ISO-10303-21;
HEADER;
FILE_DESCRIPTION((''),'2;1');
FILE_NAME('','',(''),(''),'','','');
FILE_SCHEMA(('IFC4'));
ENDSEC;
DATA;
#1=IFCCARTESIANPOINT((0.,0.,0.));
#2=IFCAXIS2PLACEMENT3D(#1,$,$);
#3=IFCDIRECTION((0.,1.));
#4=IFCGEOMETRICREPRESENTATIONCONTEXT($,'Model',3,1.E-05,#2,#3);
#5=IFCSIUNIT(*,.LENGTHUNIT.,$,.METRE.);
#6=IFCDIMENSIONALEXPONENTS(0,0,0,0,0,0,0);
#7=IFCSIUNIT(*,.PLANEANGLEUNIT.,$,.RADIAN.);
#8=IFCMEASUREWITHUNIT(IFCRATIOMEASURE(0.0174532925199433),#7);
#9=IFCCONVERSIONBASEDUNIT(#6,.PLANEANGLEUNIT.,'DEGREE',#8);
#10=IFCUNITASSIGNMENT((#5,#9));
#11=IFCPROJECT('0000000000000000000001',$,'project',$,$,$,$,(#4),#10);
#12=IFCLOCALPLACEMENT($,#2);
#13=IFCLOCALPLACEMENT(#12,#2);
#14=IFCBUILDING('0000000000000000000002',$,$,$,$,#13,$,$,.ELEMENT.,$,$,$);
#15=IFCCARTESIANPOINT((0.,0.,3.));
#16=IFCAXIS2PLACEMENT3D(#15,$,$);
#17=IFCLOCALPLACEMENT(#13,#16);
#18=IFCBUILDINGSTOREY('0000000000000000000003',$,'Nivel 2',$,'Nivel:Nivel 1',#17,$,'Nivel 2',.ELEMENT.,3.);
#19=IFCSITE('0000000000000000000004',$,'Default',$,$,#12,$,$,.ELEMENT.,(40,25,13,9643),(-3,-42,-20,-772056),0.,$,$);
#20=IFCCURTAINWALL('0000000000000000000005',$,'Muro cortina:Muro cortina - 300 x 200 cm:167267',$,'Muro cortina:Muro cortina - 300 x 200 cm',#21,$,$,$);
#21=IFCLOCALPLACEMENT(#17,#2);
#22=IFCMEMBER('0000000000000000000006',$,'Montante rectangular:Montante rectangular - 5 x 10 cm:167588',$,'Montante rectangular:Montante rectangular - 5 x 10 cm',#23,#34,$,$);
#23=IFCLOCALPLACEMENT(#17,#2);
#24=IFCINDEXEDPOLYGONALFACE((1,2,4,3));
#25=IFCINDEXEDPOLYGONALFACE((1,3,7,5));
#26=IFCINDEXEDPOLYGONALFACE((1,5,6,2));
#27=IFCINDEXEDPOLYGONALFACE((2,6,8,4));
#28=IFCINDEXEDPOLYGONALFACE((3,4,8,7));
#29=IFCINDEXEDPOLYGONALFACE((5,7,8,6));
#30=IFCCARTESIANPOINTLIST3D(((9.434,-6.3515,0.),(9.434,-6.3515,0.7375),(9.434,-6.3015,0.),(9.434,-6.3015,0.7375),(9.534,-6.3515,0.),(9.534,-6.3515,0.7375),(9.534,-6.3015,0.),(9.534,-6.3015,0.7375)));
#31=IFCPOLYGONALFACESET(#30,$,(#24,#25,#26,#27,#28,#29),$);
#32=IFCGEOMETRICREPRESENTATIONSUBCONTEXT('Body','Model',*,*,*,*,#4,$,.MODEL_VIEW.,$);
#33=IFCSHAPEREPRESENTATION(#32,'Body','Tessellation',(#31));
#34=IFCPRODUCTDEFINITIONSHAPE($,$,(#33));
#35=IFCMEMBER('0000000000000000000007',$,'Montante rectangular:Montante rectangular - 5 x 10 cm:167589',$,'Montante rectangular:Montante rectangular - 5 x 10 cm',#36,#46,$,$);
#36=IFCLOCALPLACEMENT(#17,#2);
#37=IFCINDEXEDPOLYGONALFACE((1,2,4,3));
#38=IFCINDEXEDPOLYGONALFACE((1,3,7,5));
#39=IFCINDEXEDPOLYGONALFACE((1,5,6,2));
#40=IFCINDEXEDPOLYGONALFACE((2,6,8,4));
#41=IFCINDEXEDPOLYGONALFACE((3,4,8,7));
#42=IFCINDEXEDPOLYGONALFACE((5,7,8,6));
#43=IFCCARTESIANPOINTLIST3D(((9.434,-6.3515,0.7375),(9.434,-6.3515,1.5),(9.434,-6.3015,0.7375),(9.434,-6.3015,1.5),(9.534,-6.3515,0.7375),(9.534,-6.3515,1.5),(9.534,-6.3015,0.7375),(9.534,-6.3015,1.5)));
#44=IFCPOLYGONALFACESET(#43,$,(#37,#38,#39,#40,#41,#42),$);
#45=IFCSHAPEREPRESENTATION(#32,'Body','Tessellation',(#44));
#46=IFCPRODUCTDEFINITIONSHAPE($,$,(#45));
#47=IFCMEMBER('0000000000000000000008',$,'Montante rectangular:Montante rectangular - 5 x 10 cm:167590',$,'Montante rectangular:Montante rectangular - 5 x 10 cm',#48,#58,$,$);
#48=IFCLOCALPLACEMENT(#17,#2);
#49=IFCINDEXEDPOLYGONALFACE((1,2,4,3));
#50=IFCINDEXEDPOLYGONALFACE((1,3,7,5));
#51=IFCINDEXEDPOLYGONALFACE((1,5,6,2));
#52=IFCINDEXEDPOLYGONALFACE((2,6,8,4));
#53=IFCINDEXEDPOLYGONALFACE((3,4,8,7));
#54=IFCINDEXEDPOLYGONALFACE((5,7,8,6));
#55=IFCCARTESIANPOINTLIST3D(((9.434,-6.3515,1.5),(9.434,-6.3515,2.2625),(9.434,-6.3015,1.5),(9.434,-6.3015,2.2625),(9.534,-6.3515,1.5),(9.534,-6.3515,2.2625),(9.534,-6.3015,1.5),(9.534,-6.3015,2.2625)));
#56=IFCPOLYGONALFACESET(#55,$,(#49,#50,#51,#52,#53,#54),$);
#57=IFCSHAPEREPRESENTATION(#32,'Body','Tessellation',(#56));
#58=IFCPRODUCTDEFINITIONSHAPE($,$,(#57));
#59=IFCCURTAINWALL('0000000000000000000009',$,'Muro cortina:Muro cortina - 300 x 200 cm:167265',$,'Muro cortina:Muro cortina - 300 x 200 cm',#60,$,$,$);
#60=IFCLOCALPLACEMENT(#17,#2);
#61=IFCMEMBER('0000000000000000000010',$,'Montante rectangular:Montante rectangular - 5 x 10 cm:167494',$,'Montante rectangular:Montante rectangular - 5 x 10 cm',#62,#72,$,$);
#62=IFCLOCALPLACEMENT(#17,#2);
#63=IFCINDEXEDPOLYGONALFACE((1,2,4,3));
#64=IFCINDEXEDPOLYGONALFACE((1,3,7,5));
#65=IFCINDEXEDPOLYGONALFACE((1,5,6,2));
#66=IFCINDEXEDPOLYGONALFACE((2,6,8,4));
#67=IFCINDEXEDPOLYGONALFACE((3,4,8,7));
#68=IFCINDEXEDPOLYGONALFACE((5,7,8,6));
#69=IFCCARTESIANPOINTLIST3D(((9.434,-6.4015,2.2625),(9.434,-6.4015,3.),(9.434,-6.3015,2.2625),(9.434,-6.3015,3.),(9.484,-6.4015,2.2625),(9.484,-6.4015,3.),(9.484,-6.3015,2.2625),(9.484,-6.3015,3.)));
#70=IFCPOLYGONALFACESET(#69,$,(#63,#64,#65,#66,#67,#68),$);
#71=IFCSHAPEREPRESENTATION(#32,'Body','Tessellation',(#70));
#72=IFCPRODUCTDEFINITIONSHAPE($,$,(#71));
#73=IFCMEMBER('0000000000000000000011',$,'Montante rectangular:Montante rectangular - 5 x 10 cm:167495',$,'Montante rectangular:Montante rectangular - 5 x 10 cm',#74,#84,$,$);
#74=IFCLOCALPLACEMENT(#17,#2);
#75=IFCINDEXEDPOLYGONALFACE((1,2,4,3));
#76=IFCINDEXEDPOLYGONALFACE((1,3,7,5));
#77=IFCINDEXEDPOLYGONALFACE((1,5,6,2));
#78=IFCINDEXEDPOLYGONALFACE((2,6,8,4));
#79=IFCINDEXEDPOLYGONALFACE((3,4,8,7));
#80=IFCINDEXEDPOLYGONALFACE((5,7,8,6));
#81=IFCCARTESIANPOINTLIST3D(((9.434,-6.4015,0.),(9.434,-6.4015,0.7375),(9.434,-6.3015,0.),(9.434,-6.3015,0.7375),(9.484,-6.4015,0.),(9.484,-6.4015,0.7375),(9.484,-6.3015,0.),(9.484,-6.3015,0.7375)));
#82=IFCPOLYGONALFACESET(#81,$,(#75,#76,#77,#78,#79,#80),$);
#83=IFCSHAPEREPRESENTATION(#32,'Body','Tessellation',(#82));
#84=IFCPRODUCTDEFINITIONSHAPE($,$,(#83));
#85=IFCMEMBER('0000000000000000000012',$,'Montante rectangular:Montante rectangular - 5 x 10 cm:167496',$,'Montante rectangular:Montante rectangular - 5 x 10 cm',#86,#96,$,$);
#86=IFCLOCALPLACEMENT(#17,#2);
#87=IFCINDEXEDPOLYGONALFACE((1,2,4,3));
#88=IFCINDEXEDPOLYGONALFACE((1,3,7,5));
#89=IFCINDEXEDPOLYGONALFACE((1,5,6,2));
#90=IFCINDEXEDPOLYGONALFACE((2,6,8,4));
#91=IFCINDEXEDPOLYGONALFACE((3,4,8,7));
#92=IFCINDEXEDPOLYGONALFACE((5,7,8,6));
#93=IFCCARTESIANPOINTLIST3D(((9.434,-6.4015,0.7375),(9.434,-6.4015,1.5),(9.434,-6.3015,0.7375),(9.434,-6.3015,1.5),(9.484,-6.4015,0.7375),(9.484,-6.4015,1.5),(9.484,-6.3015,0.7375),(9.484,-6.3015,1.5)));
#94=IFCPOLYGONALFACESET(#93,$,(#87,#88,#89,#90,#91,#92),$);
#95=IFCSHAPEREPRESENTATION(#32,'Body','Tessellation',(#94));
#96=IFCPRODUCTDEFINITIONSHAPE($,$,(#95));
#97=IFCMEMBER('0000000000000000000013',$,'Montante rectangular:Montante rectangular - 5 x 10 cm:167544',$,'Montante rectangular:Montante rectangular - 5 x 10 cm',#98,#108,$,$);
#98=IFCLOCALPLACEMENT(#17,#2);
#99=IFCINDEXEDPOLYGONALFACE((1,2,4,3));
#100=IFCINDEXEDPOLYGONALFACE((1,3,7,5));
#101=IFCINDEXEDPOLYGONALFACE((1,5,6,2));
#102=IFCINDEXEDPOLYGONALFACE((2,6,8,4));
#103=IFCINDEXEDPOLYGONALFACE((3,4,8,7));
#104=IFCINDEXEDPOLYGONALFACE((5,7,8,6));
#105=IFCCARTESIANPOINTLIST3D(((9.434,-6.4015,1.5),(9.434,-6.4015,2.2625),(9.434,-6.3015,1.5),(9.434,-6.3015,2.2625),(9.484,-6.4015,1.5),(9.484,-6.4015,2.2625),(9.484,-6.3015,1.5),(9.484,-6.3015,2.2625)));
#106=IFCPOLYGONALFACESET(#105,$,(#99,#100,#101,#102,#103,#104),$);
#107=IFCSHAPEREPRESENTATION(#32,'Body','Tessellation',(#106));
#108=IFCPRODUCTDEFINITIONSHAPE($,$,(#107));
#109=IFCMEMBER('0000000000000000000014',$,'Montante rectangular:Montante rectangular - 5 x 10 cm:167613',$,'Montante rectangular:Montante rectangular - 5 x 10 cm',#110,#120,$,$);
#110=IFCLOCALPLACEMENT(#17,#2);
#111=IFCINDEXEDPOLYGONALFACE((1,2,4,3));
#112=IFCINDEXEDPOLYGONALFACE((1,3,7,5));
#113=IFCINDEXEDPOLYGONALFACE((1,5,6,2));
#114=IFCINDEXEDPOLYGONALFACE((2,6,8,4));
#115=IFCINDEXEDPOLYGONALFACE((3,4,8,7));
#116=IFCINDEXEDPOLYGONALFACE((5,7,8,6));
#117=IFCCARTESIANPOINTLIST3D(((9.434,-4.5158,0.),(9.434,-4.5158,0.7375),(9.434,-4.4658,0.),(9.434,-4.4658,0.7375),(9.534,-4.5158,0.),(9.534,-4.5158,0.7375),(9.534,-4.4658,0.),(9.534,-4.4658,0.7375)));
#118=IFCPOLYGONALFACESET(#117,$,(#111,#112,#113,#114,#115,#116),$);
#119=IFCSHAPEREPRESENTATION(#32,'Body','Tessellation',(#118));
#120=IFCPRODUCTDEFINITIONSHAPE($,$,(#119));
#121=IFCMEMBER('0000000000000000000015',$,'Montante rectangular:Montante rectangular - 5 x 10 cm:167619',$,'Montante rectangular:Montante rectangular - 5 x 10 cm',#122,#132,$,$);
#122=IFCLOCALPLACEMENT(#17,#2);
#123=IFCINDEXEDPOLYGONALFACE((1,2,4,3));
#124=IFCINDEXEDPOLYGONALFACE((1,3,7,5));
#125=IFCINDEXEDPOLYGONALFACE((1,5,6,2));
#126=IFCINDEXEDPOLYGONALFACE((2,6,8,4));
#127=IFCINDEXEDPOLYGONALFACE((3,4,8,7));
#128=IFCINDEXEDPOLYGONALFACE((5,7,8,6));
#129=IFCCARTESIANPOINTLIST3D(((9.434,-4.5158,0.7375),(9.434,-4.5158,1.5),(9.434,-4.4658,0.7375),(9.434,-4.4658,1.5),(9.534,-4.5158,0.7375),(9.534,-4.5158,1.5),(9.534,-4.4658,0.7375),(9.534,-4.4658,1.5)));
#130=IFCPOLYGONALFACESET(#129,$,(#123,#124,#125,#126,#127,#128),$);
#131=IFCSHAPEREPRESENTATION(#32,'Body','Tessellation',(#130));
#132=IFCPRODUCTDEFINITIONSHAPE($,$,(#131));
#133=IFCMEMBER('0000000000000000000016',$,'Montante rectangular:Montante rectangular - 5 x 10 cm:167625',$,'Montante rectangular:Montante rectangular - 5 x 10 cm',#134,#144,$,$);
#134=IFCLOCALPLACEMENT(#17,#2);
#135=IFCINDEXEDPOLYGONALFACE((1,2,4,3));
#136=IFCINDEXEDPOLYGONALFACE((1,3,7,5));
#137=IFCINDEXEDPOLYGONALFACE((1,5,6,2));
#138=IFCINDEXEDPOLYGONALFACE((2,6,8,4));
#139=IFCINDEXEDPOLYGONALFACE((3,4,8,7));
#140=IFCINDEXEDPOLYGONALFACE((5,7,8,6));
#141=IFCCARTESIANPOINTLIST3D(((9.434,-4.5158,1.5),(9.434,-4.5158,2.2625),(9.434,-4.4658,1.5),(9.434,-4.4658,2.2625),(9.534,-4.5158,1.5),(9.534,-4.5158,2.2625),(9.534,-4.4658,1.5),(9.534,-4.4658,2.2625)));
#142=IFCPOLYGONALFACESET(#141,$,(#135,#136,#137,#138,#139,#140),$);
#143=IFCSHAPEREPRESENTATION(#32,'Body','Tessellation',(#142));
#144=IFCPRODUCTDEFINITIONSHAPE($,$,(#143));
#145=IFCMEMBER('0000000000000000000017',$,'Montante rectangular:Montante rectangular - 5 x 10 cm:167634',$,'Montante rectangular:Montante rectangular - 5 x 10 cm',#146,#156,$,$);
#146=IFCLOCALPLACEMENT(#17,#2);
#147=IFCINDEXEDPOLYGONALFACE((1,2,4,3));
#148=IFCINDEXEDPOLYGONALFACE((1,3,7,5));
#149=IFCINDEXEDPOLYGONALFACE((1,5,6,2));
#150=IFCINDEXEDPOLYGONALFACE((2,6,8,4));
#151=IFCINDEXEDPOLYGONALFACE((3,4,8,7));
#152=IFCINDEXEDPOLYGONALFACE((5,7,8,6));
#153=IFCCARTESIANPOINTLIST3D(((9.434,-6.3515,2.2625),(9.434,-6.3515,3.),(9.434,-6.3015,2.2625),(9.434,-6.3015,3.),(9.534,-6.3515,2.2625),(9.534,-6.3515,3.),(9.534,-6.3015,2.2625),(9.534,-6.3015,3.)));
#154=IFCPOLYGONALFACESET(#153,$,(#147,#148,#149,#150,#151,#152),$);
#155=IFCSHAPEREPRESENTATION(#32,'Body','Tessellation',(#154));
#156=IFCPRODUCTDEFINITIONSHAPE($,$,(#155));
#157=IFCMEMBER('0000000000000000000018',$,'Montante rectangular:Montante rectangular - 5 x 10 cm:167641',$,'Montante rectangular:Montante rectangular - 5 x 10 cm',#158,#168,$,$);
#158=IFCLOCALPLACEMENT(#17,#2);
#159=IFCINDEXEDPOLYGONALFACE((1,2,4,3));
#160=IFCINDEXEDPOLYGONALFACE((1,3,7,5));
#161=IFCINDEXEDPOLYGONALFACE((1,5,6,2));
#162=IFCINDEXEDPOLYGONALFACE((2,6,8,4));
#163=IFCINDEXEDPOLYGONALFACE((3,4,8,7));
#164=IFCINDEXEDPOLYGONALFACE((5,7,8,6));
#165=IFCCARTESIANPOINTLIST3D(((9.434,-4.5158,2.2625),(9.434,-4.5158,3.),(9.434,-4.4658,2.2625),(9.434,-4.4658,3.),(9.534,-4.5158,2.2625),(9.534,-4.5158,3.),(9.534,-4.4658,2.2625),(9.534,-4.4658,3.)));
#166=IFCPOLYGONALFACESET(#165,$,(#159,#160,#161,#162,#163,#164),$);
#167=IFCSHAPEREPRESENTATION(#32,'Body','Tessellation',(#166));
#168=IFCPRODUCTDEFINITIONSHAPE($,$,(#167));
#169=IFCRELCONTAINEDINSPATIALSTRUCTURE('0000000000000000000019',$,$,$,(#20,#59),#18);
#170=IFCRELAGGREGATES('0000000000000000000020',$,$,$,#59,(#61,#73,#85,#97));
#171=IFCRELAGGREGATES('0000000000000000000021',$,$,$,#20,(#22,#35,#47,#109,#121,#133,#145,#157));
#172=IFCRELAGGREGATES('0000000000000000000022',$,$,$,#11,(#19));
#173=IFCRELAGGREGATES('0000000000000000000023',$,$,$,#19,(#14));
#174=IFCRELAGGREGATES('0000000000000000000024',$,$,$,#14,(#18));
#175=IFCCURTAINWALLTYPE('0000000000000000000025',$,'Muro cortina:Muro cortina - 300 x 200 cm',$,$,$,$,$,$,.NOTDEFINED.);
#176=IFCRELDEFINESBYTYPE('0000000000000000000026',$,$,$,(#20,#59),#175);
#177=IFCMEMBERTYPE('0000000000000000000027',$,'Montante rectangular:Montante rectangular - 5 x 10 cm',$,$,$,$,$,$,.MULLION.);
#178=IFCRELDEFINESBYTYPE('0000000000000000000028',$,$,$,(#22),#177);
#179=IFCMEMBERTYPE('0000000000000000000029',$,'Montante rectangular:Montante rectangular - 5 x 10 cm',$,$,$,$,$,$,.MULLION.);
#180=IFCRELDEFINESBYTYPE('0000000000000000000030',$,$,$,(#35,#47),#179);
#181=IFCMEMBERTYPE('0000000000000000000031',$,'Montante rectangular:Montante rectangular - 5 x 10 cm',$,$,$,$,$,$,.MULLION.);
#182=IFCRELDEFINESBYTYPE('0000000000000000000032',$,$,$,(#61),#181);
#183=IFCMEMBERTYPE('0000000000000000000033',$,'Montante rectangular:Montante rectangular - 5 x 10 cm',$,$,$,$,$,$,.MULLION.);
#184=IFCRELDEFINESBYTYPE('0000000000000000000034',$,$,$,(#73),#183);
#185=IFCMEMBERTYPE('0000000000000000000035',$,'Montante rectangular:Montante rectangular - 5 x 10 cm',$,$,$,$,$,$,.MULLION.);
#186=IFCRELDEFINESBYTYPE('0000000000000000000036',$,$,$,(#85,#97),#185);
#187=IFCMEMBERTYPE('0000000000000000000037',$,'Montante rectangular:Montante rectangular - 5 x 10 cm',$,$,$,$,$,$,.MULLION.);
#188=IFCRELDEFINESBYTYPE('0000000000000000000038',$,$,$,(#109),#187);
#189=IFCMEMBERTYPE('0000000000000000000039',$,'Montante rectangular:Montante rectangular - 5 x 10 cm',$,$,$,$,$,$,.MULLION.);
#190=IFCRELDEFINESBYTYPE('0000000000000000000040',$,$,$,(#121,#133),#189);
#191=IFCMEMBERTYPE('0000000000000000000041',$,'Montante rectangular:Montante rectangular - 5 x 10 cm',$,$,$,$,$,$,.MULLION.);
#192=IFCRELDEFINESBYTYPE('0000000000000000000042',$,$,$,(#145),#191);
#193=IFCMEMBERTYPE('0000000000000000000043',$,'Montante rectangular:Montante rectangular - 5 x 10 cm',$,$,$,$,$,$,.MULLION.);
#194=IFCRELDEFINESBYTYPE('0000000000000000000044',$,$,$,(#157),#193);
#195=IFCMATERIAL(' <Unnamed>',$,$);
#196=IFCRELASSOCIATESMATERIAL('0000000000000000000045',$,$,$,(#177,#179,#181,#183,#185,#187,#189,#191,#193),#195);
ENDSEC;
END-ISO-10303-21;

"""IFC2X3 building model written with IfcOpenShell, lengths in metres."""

from ifc_helpers import new_model, entity, si_unit, converted_unit, direction, frame, origin, origin_2d_with_axis, place, context, subcontext, project, spatial, rectangle, extrude, source, transform, mapped, material, type_object, type_shapes, element, aggregate, save


model = new_model("IFC2X3")

# Units and contexts
model_context = context("Model", 3, precision=1e-05, world=origin(), true_north=direction((0.0, 1.0)))
body_context = subcontext(model_context, "Body", "Model", "MODEL_VIEW")
ifc_project = project(units=[si_unit("LENGTHUNIT", "METRE"), converted_unit("PLANEANGLEUNIT", "DEGREE", entity("IfcRatioMeasure", 0.0174532925199433), si_unit("PLANEANGLEUNIT", "RADIAN"), dimensions=[0, 0, 0, 0, 0, 0, 0])], contexts=[model_context])

# Site, building, storey
site_placement = place(None, origin())
site = spatial("IfcSite", under=ifc_project, at=site_placement, Name="Default", CompositionType="ELEMENT", RefLatitude=(40, 25, 13, 9643), RefLongitude=(-3, -42, -20, -772056), RefElevation=0.0)
building_placement = place(site_placement, origin())
building = spatial("IfcBuilding", under=site, at=building_placement, CompositionType="ELEMENT")
storey_placement = place(building_placement, frame((0.0, 0.0, 3.0)))
storey = spatial("IfcBuildingStorey", under=building, at=storey_placement, Name="Nivel 2", ObjectType="Nivel:Nivel 1", LongName="Nivel 2", CompositionType="ELEMENT", Elevation=3.0)

# Curtain walls, members
curtain_wall_type = type_object("IfcCurtainWallType", Name="Muro cortina:Muro cortina - 300 x 200 cm", PredefinedType="NOTDEFINED")
curtain_wall_1_placement = place(storey_placement, frame((0.0, 0.0, -3.0)))
curtain_wall_1 = element("IfcCurtainWall", 1, at=curtain_wall_1_placement, inside=storey, type_object=curtain_wall_type, Name="Muro cortina:Muro cortina - 300 x 200 cm:167267", ObjectType="Muro cortina:Muro cortina - 300 x 200 cm")
ifc_material_1 = material(Name=" <Unnamed>")
member_type_1 = type_object("IfcMemberType", Name="Montante rectangular:Montante rectangular - 5 x 10 cm", PredefinedType="MULLION", material=ifc_material_1)
shared_shape_1 = source(origin(), body_context, "Body", "SweptSolid", [
    extrude(rectangle(XDim=0.1, YDim=0.05, at=origin_2d_with_axis()), frame((-0.025, 0.0, -0.7375), z_axis=(0.0, 0.0, 1.0), x_axis=(0.0, -1.0, 0.0)), (0.0, 0.0, 1.0), 0.7375),
])
type_shapes(member_type_1, [shared_shape_1])
member_1_placement = place(storey_placement, frame((9.484, -6.3515, 0.0), z_axis=(0.0, 0.0, -1.0), x_axis=(0.0, -1.0, 0.0)))
member_1 = element("IfcMember", 2, at=member_1_placement, type_object=member_type_1, Name="Montante rectangular:Montante rectangular - 5 x 10 cm:167588", ObjectType="Montante rectangular:Montante rectangular - 5 x 10 cm", context=body_context, shape_type="MappedRepresentation", body=[
    mapped(shared_shape_1, transform((0.0, 0.0, 0.0), scale=1.0)),
])
member_type_2 = type_object("IfcMemberType", Name="Montante rectangular:Montante rectangular - 5 x 10 cm", PredefinedType="MULLION", material=ifc_material_1)
shared_shape_2 = source(origin(), body_context, "Body", "SweptSolid", [
    extrude(rectangle(XDim=0.1, YDim=0.05, at=origin_2d_with_axis()), frame((-0.025, 0.0, -0.7625), z_axis=(0.0, 0.0, 1.0), x_axis=(0.0, -1.0, 0.0)), (0.0, 0.0, 1.0), 0.7625),
])
type_shapes(member_type_2, [shared_shape_2])
member_2_placement = place(storey_placement, frame((9.484, -6.3515, 0.7375), z_axis=(0.0, 0.0, -1.0), x_axis=(0.0, -1.0, 0.0)))
member_2 = element("IfcMember", 3, at=member_2_placement, type_object=member_type_2, Name="Montante rectangular:Montante rectangular - 5 x 10 cm:167589", ObjectType="Montante rectangular:Montante rectangular - 5 x 10 cm", context=body_context, shape_type="MappedRepresentation", body=[
    mapped(shared_shape_2, transform((0.0, 0.0, 0.0), scale=1.0)),
])
member_3_placement = place(storey_placement, frame((9.484, -6.3515, 1.5), z_axis=(0.0, 0.0, -1.0), x_axis=(0.0, -1.0, 0.0)))
member_3 = element("IfcMember", 4, at=member_3_placement, type_object=member_type_2, Name="Montante rectangular:Montante rectangular - 5 x 10 cm:167590", ObjectType="Montante rectangular:Montante rectangular - 5 x 10 cm", context=body_context, shape_type="MappedRepresentation", body=[
    mapped(shared_shape_2, transform((0.0, 0.0, 0.0), scale=1.0)),
])
curtain_wall_2_placement = place(storey_placement, frame((0.0, 0.0, -3.0)))
curtain_wall_2 = element("IfcCurtainWall", 5, at=curtain_wall_2_placement, inside=storey, type_object=curtain_wall_type, Name="Muro cortina:Muro cortina - 300 x 200 cm:167265", ObjectType="Muro cortina:Muro cortina - 300 x 200 cm")
member_type_3 = type_object("IfcMemberType", Name="Montante rectangular:Montante rectangular - 5 x 10 cm", PredefinedType="MULLION", material=ifc_material_1)
shared_shape_3 = source(origin(), body_context, "Body", "SweptSolid", [
    extrude(rectangle(XDim=0.1, YDim=0.05, at=origin_2d_with_axis()), frame((-0.025, 0.0, -0.7375), z_axis=(0.0, 0.0, 1.0), x_axis=(0.0, -1.0, 0.0)), (0.0, 0.0, 1.0), 0.7375),
])
type_shapes(member_type_3, [shared_shape_3])
member_4_placement = place(storey_placement, frame((9.484, -6.3515, 3.0)))
member_4 = element("IfcMember", 6, at=member_4_placement, type_object=member_type_3, Name="Montante rectangular:Montante rectangular - 5 x 10 cm:167494", ObjectType="Montante rectangular:Montante rectangular - 5 x 10 cm", context=body_context, shape_type="MappedRepresentation", body=[
    mapped(shared_shape_3, transform((0.0, 0.0, 0.0), scale=1.0)),
])
member_type_4 = type_object("IfcMemberType", Name="Montante rectangular:Montante rectangular - 5 x 10 cm", PredefinedType="MULLION", material=ifc_material_1)
shared_shape_4 = source(origin(), body_context, "Body", "SweptSolid", [
    extrude(rectangle(XDim=0.1, YDim=0.05, at=origin_2d_with_axis()), frame((-0.025, 0.0, -0.7375), z_axis=(0.0, 0.0, 1.0), x_axis=(0.0, -1.0, 0.0)), (0.0, 0.0, 1.0), 0.7375),
])
type_shapes(member_type_4, [shared_shape_4])
member_5_placement = place(storey_placement, frame((9.484, -6.3515, 0.7375)))
member_5 = element("IfcMember", 7, at=member_5_placement, type_object=member_type_4, Name="Montante rectangular:Montante rectangular - 5 x 10 cm:167495", ObjectType="Montante rectangular:Montante rectangular - 5 x 10 cm", context=body_context, shape_type="MappedRepresentation", body=[
    mapped(shared_shape_4, transform((0.0, 0.0, 0.0), scale=1.0)),
])
member_type_5 = type_object("IfcMemberType", Name="Montante rectangular:Montante rectangular - 5 x 10 cm", PredefinedType="MULLION", material=ifc_material_1)
shared_shape_5 = source(origin(), body_context, "Body", "SweptSolid", [
    extrude(rectangle(XDim=0.1, YDim=0.05, at=origin_2d_with_axis()), frame((-0.025, 0.0, -0.7625), z_axis=(0.0, 0.0, 1.0), x_axis=(0.0, -1.0, 0.0)), (0.0, 0.0, 1.0), 0.7625),
])
type_shapes(member_type_5, [shared_shape_5])
member_6_placement = place(storey_placement, frame((9.484, -6.3515, 1.5)))
member_6 = element("IfcMember", 8, at=member_6_placement, type_object=member_type_5, Name="Montante rectangular:Montante rectangular - 5 x 10 cm:167496", ObjectType="Montante rectangular:Montante rectangular - 5 x 10 cm", context=body_context, shape_type="MappedRepresentation", body=[
    mapped(shared_shape_5, transform((0.0, 0.0, 0.0), scale=1.0)),
])
member_7_placement = place(storey_placement, frame((9.484, -6.3515, 2.2625)))
member_7 = element("IfcMember", 9, at=member_7_placement, type_object=member_type_5, Name="Montante rectangular:Montante rectangular - 5 x 10 cm:167544", ObjectType="Montante rectangular:Montante rectangular - 5 x 10 cm", context=body_context, shape_type="MappedRepresentation", body=[
    mapped(shared_shape_5, transform((0.0, 0.0, 0.0), scale=1.0)),
])

# Members
member_type_6 = type_object("IfcMemberType", Name="Montante rectangular:Montante rectangular - 5 x 10 cm", PredefinedType="MULLION", material=ifc_material_1)
shared_shape_6 = source(origin(), body_context, "Body", "SweptSolid", [
    extrude(rectangle(XDim=0.1, YDim=0.05, at=origin_2d_with_axis()), frame((0.0, 0.0, -0.7375), z_axis=(0.0, 0.0, 1.0), x_axis=(0.0, -1.0, 0.0)), (0.0, 0.0, 1.0), 0.7375),
])
type_shapes(member_type_6, [shared_shape_6])
member_8_placement = place(storey_placement, frame((9.484, -4.4908, 0.0), z_axis=(0.0, 0.0, -1.0), x_axis=(0.0, -1.0, 0.0)))
member_8 = element("IfcMember", 10, at=member_8_placement, type_object=member_type_6, Name="Montante rectangular:Montante rectangular - 5 x 10 cm:167613", ObjectType="Montante rectangular:Montante rectangular - 5 x 10 cm", context=body_context, shape_type="MappedRepresentation", body=[
    mapped(shared_shape_6, transform((0.0, 0.0, 0.0), scale=1.0)),
])
member_type_7 = type_object("IfcMemberType", Name="Montante rectangular:Montante rectangular - 5 x 10 cm", PredefinedType="MULLION", material=ifc_material_1)
shared_shape_7 = source(origin(), body_context, "Body", "SweptSolid", [
    extrude(rectangle(XDim=0.1, YDim=0.05, at=origin_2d_with_axis()), frame((0.0, 0.0, -0.7625), z_axis=(0.0, 0.0, 1.0), x_axis=(0.0, -1.0, 0.0)), (0.0, 0.0, 1.0), 0.7625),
])
type_shapes(member_type_7, [shared_shape_7])
member_9_placement = place(storey_placement, frame((9.484, -4.4908, 0.7375), z_axis=(0.0, 0.0, -1.0), x_axis=(0.0, -1.0, 0.0)))
member_9 = element("IfcMember", 11, at=member_9_placement, type_object=member_type_7, Name="Montante rectangular:Montante rectangular - 5 x 10 cm:167619", ObjectType="Montante rectangular:Montante rectangular - 5 x 10 cm", context=body_context, shape_type="MappedRepresentation", body=[
    mapped(shared_shape_7, transform((0.0, 0.0, 0.0), scale=1.0)),
])
member_10_placement = place(storey_placement, frame((9.484, -4.4908, 1.5), z_axis=(0.0, 0.0, -1.0), x_axis=(0.0, -1.0, 0.0)))
member_10 = element("IfcMember", 12, at=member_10_placement, type_object=member_type_7, Name="Montante rectangular:Montante rectangular - 5 x 10 cm:167625", ObjectType="Montante rectangular:Montante rectangular - 5 x 10 cm", context=body_context, shape_type="MappedRepresentation", body=[
    mapped(shared_shape_7, transform((0.0, 0.0, 0.0), scale=1.0)),
])
member_type_8 = type_object("IfcMemberType", Name="Montante rectangular:Montante rectangular - 5 x 10 cm", PredefinedType="MULLION", material=ifc_material_1)
shared_shape_8 = source(origin(), body_context, "Body", "SweptSolid", [
    extrude(rectangle(XDim=0.1, YDim=0.05, at=origin_2d_with_axis()), frame((-0.025, 0.0, -0.7375), z_axis=(0.0, 0.0, 1.0), x_axis=(0.0, -1.0, 0.0)), (0.0, 0.0, 1.0), 0.7375),
])
type_shapes(member_type_8, [shared_shape_8])
member_11_placement = place(storey_placement, frame((9.484, -6.3515, 2.2625), z_axis=(0.0, 0.0, -1.0), x_axis=(0.0, -1.0, 0.0)))
member_11 = element("IfcMember", 13, at=member_11_placement, type_object=member_type_8, Name="Montante rectangular:Montante rectangular - 5 x 10 cm:167634", ObjectType="Montante rectangular:Montante rectangular - 5 x 10 cm", context=body_context, shape_type="MappedRepresentation", body=[
    mapped(shared_shape_8, transform((0.0, 0.0, 0.0), scale=1.0)),
])
member_type_9 = type_object("IfcMemberType", Name="Montante rectangular:Montante rectangular - 5 x 10 cm", PredefinedType="MULLION", material=ifc_material_1)
shared_shape_9 = source(origin(), body_context, "Body", "SweptSolid", [
    extrude(rectangle(XDim=0.1, YDim=0.05, at=origin_2d_with_axis()), frame((0.0, 0.0, -0.7375), z_axis=(0.0, 0.0, 1.0), x_axis=(0.0, -1.0, 0.0)), (0.0, 0.0, 1.0), 0.7375),
])
type_shapes(member_type_9, [shared_shape_9])
member_12_placement = place(storey_placement, frame((9.484, -4.4908, 2.2625), z_axis=(0.0, 0.0, -1.0), x_axis=(0.0, -1.0, 0.0)))
member_12 = element("IfcMember", 14, at=member_12_placement, type_object=member_type_9, Name="Montante rectangular:Montante rectangular - 5 x 10 cm:167641", ObjectType="Montante rectangular:Montante rectangular - 5 x 10 cm", context=body_context, shape_type="MappedRepresentation", body=[
    mapped(shared_shape_9, transform((0.0, 0.0, 0.0), scale=1.0)),
])

aggregate(curtain_wall_2, [member_4, member_5, member_6, member_7])
aggregate(curtain_wall_1, [member_1, member_2, member_3, member_8, member_9, member_10, member_11, member_12])

save(model, "model.ifc")
